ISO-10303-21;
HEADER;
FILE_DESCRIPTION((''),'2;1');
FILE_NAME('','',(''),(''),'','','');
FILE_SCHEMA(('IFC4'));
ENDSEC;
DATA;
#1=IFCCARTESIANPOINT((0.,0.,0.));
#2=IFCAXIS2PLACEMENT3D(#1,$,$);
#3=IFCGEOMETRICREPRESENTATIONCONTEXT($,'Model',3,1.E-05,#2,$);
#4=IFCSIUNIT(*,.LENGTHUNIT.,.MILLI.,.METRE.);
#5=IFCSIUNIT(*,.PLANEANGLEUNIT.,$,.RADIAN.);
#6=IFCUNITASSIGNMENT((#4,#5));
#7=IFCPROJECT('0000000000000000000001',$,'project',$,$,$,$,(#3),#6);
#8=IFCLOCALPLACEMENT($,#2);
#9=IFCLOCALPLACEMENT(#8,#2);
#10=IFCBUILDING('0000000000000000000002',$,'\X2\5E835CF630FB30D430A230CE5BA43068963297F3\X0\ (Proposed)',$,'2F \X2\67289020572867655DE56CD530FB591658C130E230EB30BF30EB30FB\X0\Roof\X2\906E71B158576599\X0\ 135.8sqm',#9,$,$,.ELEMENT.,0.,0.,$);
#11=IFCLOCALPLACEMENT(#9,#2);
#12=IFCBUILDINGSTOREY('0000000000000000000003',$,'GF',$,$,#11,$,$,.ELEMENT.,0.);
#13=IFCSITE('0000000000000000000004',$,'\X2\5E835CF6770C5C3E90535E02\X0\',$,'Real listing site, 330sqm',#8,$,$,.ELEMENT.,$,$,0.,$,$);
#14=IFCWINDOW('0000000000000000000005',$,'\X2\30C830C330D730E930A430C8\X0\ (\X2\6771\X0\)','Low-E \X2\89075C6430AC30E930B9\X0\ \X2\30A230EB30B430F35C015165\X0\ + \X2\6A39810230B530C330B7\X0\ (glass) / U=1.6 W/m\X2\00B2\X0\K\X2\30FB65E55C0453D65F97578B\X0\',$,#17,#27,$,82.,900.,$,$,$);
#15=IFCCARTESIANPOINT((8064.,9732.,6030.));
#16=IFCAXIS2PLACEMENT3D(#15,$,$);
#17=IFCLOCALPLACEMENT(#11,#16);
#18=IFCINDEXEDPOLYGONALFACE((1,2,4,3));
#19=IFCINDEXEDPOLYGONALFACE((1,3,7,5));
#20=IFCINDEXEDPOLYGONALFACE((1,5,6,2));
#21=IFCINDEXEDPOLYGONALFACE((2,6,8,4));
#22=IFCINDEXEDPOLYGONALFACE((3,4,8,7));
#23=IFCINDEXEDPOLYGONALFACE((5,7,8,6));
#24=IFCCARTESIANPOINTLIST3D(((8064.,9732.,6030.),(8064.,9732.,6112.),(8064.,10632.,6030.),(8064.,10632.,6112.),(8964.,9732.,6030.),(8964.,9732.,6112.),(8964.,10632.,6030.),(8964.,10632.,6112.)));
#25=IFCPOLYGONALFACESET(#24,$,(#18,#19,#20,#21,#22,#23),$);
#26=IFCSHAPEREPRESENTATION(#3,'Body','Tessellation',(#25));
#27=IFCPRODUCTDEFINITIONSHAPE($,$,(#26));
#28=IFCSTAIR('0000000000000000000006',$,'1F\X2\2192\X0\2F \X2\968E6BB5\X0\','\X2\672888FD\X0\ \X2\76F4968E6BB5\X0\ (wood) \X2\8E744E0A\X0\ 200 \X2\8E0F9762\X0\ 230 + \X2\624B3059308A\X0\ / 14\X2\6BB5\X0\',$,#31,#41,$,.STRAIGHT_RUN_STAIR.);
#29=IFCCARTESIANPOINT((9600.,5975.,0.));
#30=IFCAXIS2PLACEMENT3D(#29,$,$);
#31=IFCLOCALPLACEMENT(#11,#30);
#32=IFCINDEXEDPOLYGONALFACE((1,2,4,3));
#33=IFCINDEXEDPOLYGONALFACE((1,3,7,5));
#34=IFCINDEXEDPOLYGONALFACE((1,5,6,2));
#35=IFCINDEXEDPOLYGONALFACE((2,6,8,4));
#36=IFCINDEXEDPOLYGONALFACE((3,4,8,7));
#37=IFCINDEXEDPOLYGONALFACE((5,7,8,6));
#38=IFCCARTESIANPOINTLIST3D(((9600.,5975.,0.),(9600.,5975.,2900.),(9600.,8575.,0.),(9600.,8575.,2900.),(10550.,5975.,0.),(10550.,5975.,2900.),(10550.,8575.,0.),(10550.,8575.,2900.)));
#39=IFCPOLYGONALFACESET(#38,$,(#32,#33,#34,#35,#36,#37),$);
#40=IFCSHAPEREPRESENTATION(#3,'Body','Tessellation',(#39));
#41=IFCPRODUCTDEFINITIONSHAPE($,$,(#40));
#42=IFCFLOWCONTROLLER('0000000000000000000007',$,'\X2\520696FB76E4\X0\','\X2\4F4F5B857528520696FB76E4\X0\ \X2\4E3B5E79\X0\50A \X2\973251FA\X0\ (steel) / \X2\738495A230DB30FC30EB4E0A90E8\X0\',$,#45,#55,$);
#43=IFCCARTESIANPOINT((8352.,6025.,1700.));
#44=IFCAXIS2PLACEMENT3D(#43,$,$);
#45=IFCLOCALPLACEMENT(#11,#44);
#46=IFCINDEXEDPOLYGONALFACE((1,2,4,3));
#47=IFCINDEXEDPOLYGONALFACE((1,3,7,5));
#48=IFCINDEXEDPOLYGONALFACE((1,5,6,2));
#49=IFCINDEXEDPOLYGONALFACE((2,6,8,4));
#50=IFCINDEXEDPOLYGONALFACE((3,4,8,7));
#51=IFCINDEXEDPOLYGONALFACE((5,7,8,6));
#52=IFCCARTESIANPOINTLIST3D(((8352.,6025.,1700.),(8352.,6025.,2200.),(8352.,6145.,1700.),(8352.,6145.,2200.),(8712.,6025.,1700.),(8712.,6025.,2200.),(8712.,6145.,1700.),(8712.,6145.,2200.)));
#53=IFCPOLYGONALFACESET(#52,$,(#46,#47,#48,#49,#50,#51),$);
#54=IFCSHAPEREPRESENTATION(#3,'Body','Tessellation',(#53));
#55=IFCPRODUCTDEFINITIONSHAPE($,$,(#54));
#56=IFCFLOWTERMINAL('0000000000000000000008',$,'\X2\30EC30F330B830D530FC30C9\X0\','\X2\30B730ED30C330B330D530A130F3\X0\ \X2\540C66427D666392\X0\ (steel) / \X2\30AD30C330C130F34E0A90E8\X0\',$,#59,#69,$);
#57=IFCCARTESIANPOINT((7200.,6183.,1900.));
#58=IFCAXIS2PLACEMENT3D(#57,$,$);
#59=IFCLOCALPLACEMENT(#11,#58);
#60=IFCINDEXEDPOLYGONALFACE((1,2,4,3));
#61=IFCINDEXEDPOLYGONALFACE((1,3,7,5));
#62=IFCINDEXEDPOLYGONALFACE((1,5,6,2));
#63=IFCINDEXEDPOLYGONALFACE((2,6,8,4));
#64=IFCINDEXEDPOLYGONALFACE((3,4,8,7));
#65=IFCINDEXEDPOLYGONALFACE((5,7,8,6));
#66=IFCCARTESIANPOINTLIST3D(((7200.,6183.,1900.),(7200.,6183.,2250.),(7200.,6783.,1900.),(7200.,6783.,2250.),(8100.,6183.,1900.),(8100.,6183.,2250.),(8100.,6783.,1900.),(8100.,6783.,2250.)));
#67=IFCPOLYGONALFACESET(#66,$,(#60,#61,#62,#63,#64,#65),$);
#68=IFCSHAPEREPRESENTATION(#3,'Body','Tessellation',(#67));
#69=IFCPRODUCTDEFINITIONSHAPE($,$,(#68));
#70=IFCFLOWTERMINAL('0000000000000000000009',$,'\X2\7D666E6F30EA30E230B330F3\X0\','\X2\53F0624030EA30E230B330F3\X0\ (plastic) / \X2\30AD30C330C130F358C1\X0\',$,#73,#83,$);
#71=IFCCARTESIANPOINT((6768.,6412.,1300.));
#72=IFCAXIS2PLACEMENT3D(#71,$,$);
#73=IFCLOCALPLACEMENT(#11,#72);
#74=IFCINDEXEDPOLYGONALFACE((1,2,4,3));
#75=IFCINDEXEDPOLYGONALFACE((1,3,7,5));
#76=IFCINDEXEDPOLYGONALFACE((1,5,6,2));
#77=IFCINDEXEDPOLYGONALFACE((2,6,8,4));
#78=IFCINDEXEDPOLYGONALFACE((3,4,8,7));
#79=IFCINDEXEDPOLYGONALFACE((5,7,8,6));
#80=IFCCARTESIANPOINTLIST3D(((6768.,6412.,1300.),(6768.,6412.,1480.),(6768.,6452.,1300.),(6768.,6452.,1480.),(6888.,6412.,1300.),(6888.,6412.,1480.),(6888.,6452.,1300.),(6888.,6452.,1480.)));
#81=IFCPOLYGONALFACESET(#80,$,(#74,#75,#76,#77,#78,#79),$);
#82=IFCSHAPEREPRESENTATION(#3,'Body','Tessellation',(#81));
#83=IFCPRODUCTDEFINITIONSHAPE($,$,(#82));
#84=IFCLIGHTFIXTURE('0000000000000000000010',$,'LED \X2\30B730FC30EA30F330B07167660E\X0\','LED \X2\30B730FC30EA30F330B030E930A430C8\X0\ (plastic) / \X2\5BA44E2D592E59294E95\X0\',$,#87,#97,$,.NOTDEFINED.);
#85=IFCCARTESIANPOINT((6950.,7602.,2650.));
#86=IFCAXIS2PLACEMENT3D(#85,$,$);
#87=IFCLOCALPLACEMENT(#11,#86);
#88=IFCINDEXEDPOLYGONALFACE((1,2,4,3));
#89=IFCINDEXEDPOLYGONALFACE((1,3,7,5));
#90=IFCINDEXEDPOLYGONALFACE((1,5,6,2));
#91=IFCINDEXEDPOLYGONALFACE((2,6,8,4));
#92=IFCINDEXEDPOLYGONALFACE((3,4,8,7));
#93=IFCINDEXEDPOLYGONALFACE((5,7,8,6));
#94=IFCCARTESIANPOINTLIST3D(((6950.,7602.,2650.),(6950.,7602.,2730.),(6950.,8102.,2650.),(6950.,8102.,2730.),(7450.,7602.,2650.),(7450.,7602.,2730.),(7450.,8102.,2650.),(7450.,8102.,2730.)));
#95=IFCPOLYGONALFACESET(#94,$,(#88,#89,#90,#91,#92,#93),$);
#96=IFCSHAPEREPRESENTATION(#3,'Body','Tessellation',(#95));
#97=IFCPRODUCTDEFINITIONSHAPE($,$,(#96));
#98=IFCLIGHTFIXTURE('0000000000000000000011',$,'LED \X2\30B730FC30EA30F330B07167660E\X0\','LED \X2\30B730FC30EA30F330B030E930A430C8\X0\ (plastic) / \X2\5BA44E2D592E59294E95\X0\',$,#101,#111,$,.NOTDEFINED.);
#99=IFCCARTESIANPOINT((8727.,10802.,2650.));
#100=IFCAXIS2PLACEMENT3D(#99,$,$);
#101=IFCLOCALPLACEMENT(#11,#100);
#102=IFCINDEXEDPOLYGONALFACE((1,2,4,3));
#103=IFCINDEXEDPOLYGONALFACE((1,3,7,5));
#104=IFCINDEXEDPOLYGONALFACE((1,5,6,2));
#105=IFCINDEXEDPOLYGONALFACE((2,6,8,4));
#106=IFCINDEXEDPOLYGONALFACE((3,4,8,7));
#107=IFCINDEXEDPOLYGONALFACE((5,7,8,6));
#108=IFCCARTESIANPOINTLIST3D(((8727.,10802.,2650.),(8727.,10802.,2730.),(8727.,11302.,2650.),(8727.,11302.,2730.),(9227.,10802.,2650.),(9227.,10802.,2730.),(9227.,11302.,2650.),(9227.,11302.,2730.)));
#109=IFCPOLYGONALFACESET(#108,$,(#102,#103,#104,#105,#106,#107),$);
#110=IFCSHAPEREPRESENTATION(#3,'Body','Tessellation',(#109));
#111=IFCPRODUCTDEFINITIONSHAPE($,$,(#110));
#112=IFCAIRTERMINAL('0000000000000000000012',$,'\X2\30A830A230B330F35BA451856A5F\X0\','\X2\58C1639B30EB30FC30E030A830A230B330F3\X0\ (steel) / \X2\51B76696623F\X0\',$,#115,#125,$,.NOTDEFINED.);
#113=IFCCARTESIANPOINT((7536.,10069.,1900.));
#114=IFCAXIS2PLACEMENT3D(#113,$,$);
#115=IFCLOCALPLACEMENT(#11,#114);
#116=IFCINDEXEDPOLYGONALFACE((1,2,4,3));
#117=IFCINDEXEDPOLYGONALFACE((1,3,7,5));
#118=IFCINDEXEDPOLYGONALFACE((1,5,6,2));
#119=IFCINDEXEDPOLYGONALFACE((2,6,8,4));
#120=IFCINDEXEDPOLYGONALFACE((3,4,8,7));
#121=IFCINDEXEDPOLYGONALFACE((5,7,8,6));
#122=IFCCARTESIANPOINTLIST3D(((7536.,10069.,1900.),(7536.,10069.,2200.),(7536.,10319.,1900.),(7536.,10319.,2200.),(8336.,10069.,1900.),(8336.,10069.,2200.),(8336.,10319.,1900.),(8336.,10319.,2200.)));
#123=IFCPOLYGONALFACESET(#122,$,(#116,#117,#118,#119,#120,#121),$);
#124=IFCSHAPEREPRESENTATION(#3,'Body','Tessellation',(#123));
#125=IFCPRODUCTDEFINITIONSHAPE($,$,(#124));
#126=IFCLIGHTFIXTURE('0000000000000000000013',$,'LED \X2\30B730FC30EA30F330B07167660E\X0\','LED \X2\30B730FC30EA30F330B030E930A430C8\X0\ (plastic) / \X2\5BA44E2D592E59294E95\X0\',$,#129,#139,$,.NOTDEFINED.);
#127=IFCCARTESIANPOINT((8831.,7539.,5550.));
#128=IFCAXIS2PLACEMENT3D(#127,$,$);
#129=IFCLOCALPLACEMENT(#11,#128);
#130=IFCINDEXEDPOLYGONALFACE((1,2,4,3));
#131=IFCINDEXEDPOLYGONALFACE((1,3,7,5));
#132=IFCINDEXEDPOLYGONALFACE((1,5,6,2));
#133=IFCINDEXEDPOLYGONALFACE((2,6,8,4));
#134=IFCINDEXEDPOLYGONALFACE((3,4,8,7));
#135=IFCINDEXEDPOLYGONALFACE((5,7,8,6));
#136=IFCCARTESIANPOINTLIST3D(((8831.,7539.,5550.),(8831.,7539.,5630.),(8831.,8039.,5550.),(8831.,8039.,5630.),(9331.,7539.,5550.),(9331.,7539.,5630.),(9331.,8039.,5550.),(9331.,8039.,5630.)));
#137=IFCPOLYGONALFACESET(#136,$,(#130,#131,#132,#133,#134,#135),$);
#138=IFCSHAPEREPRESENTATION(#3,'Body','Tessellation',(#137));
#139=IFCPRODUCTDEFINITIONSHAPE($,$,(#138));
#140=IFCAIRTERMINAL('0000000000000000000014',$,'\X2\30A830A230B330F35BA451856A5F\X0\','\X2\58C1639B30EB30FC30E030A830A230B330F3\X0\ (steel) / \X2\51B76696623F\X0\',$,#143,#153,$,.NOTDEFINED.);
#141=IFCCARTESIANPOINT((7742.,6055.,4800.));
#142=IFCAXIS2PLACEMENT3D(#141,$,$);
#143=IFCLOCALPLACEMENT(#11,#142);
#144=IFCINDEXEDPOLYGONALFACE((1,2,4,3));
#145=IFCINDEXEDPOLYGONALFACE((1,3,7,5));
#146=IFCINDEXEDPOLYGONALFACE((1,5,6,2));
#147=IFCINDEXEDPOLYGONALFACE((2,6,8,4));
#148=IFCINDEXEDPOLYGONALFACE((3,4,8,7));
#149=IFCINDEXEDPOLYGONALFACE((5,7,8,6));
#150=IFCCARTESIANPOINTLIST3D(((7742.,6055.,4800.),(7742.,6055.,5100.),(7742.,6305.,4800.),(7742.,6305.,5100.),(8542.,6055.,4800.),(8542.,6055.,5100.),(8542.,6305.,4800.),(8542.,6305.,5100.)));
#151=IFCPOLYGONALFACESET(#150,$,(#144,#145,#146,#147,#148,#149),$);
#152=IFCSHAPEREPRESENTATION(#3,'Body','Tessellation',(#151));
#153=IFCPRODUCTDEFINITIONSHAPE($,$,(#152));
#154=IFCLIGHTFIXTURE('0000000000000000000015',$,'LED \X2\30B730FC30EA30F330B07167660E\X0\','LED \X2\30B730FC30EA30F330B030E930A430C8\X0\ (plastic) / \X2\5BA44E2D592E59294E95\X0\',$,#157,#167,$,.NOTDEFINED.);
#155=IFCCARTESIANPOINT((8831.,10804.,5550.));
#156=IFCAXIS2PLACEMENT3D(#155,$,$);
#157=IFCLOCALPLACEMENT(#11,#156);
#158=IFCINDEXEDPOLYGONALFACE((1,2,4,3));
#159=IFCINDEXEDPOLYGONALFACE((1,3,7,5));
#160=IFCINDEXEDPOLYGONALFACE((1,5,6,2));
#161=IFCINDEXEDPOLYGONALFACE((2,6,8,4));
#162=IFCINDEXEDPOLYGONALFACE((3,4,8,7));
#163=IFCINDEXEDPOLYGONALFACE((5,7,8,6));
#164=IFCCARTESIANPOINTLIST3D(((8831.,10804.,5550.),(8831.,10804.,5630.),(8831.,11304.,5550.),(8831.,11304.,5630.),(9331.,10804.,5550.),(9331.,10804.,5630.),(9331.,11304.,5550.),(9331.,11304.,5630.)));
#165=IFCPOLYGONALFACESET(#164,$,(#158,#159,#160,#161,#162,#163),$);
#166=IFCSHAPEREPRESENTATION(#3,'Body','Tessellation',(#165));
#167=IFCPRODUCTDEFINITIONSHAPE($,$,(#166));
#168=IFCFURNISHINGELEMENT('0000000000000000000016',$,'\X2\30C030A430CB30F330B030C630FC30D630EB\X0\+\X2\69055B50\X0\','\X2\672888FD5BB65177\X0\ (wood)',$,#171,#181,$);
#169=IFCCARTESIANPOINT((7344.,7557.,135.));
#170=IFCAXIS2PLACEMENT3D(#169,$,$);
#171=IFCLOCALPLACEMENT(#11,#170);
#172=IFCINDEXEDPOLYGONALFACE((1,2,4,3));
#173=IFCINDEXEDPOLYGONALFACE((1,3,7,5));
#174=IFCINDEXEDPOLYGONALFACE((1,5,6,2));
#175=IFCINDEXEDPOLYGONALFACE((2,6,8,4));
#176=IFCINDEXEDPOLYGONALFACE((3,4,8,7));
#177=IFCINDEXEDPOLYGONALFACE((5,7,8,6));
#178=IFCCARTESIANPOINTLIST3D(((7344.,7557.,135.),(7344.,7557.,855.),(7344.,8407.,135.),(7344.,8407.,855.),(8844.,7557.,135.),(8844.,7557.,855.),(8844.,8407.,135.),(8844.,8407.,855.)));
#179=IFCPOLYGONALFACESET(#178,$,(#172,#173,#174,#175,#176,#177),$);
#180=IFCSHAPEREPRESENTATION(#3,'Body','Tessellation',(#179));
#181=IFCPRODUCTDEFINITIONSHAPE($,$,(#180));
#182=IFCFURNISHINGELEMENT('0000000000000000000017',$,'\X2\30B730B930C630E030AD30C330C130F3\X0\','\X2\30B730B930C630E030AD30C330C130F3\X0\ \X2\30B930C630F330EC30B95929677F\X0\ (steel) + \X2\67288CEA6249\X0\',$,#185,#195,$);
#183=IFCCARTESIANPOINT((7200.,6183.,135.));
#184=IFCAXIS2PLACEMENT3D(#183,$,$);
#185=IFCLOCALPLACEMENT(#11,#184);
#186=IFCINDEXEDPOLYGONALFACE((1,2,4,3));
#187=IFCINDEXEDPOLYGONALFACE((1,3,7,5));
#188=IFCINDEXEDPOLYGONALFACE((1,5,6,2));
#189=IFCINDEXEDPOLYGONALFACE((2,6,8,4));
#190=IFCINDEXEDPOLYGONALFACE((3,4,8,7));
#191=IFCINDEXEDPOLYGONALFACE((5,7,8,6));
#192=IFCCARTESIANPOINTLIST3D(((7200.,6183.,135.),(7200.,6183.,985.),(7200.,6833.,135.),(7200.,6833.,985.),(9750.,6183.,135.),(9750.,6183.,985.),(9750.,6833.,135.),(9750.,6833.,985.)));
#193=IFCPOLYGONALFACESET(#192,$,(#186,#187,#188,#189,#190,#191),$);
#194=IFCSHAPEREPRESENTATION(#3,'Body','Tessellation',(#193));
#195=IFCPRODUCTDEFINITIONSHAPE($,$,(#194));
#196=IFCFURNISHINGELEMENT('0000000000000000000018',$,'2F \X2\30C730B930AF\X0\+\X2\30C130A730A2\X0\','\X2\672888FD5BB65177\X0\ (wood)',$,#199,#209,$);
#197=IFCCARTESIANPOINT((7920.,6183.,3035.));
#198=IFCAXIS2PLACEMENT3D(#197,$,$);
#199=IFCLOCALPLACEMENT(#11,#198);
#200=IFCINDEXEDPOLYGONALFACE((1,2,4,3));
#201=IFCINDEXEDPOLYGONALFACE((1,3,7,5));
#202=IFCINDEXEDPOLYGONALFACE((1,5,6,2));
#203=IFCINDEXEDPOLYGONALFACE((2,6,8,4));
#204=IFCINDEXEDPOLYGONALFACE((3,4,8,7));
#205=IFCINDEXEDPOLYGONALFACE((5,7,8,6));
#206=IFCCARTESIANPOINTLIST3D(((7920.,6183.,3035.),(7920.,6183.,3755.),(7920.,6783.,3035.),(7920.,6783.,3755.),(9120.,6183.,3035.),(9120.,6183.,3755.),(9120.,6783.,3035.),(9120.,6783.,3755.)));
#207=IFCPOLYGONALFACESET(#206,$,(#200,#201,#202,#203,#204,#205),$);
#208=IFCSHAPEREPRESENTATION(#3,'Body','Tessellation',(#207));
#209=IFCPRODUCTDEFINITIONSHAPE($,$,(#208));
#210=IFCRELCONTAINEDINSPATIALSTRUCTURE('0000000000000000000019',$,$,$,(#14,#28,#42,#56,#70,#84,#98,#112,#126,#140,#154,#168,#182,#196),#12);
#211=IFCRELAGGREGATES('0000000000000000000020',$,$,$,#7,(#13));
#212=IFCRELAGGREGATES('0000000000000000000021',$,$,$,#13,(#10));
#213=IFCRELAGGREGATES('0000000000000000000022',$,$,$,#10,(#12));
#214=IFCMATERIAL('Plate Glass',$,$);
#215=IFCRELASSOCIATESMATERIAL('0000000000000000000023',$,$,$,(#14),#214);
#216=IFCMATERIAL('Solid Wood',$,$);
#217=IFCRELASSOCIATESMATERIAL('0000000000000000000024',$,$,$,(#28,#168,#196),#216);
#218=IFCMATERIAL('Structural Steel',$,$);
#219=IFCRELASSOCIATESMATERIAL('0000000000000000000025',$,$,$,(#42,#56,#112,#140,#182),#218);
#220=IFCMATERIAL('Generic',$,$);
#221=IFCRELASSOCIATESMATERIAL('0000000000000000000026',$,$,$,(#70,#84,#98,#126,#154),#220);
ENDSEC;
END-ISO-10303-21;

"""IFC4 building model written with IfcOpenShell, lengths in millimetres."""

from ifc_helpers import new_model, si_unit, frame, frame_2d, origin, place, context, project, spatial, rectangle, extrude, material, element, save


model = new_model("IFC4")

# Units and contexts
model_context = context("Model", 3, precision=1e-05, world=origin())
ifc_project = project(units=[si_unit("LENGTHUNIT", "METRE", prefix="MILLI"), si_unit("PLANEANGLEUNIT", "RADIAN")], contexts=[model_context])

# Site, building, storey
site_placement = place(None, origin())
site = spatial("IfcSite", under=ifc_project, at=site_placement, Name="広島県尾道市", ObjectType="Real listing site, 330sqm", CompositionType="ELEMENT", RefElevation=0.0)
building_placement = place(site_placement, origin())
building = spatial("IfcBuilding", under=site, at=building_placement, Name="広島・ピアノ室と防音 (Proposed)", ObjectType="2F 木造在来工法・外壁モルタル・Roof遮熱塗料 135.8sqm", CompositionType="ELEMENT", ElevationOfRefHeight=0.0, ElevationOfTerrain=0.0)
storey_placement = place(building_placement, origin())
storey = spatial("IfcBuildingStorey", under=building, at=storey_placement, Name="GF", CompositionType="ELEMENT", Elevation=0.0)

# Shared definitions
ifc_material_1 = material(Name="Solid Wood")

# Window
ifc_material_2 = material(Name="Plate Glass")
window_placement = place(storey_placement, frame((8064.0, 9732.0, 6030.0)))
element("IfcWindow", 1, at=window_placement, inside=storey, material=ifc_material_2, Name="トップライト (東)", Description="Low-E 複層ガラス アルゴン封入 + 樹脂サッシ (glass) / U=1.6 W/m²K・日射取得型", OverallHeight=82.0, OverallWidth=900.0, context=model_context, shape_type="SweptSolid", body=[
    extrude(rectangle(XDim=900.0, YDim=900.0, at=frame_2d((450.0, 450.0))), frame((8064.0, 9732.0, 6030.0)), (0.0, 0.0, 1.0), 82.0),
])

# Stair
stair_placement = place(storey_placement, frame((9600.0, 5975.0, 0.0)))
element("IfcStair", 2, at=stair_placement, inside=storey, material=ifc_material_1, Name="1F→2F 階段", Description="木製 直階段 (wood) 蹴上 200 踏面 230 + 手すり / 14段", PredefinedType="STRAIGHT_RUN_STAIR", context=model_context, shape_type="SweptSolid", body=[
    extrude(rectangle(XDim=950.0, YDim=2600.0, at=frame_2d((475.0, 1300.0))), frame((9600.0, 5975.0, 0.0)), (0.0, 0.0, 1.0), 2900.0),
])

# Flow controller
ifc_material_3 = material(Name="Structural Steel")
flow_controller_placement = place(storey_placement, frame((8352.0, 6025.0, 1700.0)))
element("IfcFlowController", 3, at=flow_controller_placement, inside=storey, material=ifc_material_3, Name="分電盤", Description="住宅用分電盤 主幹50A 露出 (steel) / 玄関ホール上部", context=model_context, shape_type="SweptSolid", body=[
    extrude(rectangle(XDim=360.0, YDim=120.0, at=frame_2d((180.0, 60.0))), frame((8352.0, 6025.0, 1700.0)), (0.0, 0.0, 1.0), 500.0),
])

# Flow terminals
flow_terminal_1_placement = place(storey_placement, frame((7200.0, 6183.0, 1900.0)))
element("IfcFlowTerminal", 4, at=flow_terminal_1_placement, inside=storey, material=ifc_material_3, Name="レンジフード", Description="シロッコファン 同時給排 (steel) / キッチン上部", context=model_context, shape_type="SweptSolid", body=[
    extrude(rectangle(XDim=900.0, YDim=600.0, at=frame_2d((450.0, 300.0))), frame((7200.0, 6183.0, 1900.0)), (0.0, 0.0, 1.0), 350.0),
])
ifc_material_4 = material(Name="Generic")
flow_terminal_2_placement = place(storey_placement, frame((6768.0, 6412.0, 1300.0)))
element("IfcFlowTerminal", 5, at=flow_terminal_2_placement, inside=storey, material=ifc_material_4, Name="給湯リモコン", Description="台所リモコン (plastic) / キッチン壁", context=model_context, shape_type="SweptSolid", body=[
    extrude(rectangle(XDim=120.0, YDim=40.0, at=frame_2d((60.0, 20.0))), frame((6768.0, 6412.0, 1300.0)), (0.0, 0.0, 1.0), 180.0),
])

# Light fixtures
light_fixture_1_placement = place(storey_placement, frame((6950.0, 7602.0, 2650.0)))
element("IfcLightFixture", 6, at=light_fixture_1_placement, inside=storey, material=ifc_material_4, Name="LED シーリング照明", Description="LED シーリングライト (plastic) / 室中央天井", PredefinedType="NOTDEFINED", context=model_context, shape_type="SweptSolid", body=[
    extrude(rectangle(XDim=500.0, YDim=500.0, at=frame_2d((250.0, 250.0))), frame((6950.0, 7602.0, 2650.0)), (0.0, 0.0, 1.0), 80.0),
])
light_fixture_2_placement = place(storey_placement, frame((8727.0, 10802.0, 2650.0)))
element("IfcLightFixture", 7, at=light_fixture_2_placement, inside=storey, material=ifc_material_4, Name="LED シーリング照明", Description="LED シーリングライト (plastic) / 室中央天井", PredefinedType="NOTDEFINED", context=model_context, shape_type="SweptSolid", body=[
    extrude(rectangle(XDim=500.0, YDim=500.0, at=frame_2d((250.0, 250.0))), frame((8727.0, 10802.0, 2650.0)), (0.0, 0.0, 1.0), 80.0),
])

# Air terminal
air_terminal_1_placement = place(storey_placement, frame((7536.0, 10069.0, 1900.0)))
element("IfcAirTerminal", 8, at=air_terminal_1_placement, inside=storey, material=ifc_material_3, Name="エアコン室内機", Description="壁掛ルームエアコン (steel) / 冷暖房", PredefinedType="NOTDEFINED", context=model_context, shape_type="SweptSolid", body=[
    extrude(rectangle(XDim=800.0, YDim=250.0, at=frame_2d((400.0, 125.0))), frame((7536.0, 10069.0, 1900.0)), (0.0, 0.0, 1.0), 300.0),
])

# Light fixture
light_fixture_3_placement = place(storey_placement, frame((8831.0, 7539.0, 5550.0)))
element("IfcLightFixture", 9, at=light_fixture_3_placement, inside=storey, material=ifc_material_4, Name="LED シーリング照明", Description="LED シーリングライト (plastic) / 室中央天井", PredefinedType="NOTDEFINED", context=model_context, shape_type="SweptSolid", body=[
    extrude(rectangle(XDim=500.0, YDim=500.0, at=frame_2d((250.0, 250.0))), frame((8831.0, 7539.0, 5550.0)), (0.0, 0.0, 1.0), 80.0),
])

# Air terminal
air_terminal_2_placement = place(storey_placement, frame((7742.0, 6055.0, 4800.0)))
element("IfcAirTerminal", 10, at=air_terminal_2_placement, inside=storey, material=ifc_material_3, Name="エアコン室内機", Description="壁掛ルームエアコン (steel) / 冷暖房", PredefinedType="NOTDEFINED", context=model_context, shape_type="SweptSolid", body=[
    extrude(rectangle(XDim=800.0, YDim=250.0, at=frame_2d((400.0, 125.0))), frame((7742.0, 6055.0, 4800.0)), (0.0, 0.0, 1.0), 300.0),
])

# Light fixture
light_fixture_4_placement = place(storey_placement, frame((8831.0, 10804.0, 5550.0)))
element("IfcLightFixture", 11, at=light_fixture_4_placement, inside=storey, material=ifc_material_4, Name="LED シーリング照明", Description="LED シーリングライト (plastic) / 室中央天井", PredefinedType="NOTDEFINED", context=model_context, shape_type="SweptSolid", body=[
    extrude(rectangle(XDim=500.0, YDim=500.0, at=frame_2d((250.0, 250.0))), frame((8831.0, 10804.0, 5550.0)), (0.0, 0.0, 1.0), 80.0),
])

# Furnishing elements
furnishing_1_placement = place(storey_placement, frame((7344.0, 7557.0, 135.0)))
element("IfcFurnishingElement", 12, at=furnishing_1_placement, inside=storey, material=ifc_material_1, Name="ダイニングテーブル+椅子", Description="木製家具 (wood)", context=model_context, shape_type="SweptSolid", body=[
    extrude(rectangle(XDim=1500.0, YDim=850.0, at=frame_2d((750.0, 425.0))), frame((7344.0, 7557.0, 135.0)), (0.0, 0.0, 1.0), 720.0),
])
furnishing_2_placement = place(storey_placement, frame((7200.0, 6183.0, 135.0)))
element("IfcFurnishingElement", 13, at=furnishing_2_placement, inside=storey, material=ifc_material_3, Name="システムキッチン", Description="システムキッチン ステンレス天板 (steel) + 木質扉", context=model_context, shape_type="SweptSolid", body=[
    extrude(rectangle(XDim=2550.0, YDim=650.0, at=frame_2d((1275.0, 325.0))), frame((7200.0, 6183.0, 135.0)), (0.0, 0.0, 1.0), 850.0),
])
furnishing_3_placement = place(storey_placement, frame((7920.0, 6183.0, 3035.0)))
element("IfcFurnishingElement", 14, at=furnishing_3_placement, inside=storey, material=ifc_material_1, Name="2F デスク+チェア", Description="木製家具 (wood)", context=model_context, shape_type="SweptSolid", body=[
    extrude(rectangle(XDim=1200.0, YDim=600.0, at=frame_2d((600.0, 300.0))), frame((7920.0, 6183.0, 3035.0)), (0.0, 0.0, 1.0), 720.0),
])

save(model, "model.ifc")
